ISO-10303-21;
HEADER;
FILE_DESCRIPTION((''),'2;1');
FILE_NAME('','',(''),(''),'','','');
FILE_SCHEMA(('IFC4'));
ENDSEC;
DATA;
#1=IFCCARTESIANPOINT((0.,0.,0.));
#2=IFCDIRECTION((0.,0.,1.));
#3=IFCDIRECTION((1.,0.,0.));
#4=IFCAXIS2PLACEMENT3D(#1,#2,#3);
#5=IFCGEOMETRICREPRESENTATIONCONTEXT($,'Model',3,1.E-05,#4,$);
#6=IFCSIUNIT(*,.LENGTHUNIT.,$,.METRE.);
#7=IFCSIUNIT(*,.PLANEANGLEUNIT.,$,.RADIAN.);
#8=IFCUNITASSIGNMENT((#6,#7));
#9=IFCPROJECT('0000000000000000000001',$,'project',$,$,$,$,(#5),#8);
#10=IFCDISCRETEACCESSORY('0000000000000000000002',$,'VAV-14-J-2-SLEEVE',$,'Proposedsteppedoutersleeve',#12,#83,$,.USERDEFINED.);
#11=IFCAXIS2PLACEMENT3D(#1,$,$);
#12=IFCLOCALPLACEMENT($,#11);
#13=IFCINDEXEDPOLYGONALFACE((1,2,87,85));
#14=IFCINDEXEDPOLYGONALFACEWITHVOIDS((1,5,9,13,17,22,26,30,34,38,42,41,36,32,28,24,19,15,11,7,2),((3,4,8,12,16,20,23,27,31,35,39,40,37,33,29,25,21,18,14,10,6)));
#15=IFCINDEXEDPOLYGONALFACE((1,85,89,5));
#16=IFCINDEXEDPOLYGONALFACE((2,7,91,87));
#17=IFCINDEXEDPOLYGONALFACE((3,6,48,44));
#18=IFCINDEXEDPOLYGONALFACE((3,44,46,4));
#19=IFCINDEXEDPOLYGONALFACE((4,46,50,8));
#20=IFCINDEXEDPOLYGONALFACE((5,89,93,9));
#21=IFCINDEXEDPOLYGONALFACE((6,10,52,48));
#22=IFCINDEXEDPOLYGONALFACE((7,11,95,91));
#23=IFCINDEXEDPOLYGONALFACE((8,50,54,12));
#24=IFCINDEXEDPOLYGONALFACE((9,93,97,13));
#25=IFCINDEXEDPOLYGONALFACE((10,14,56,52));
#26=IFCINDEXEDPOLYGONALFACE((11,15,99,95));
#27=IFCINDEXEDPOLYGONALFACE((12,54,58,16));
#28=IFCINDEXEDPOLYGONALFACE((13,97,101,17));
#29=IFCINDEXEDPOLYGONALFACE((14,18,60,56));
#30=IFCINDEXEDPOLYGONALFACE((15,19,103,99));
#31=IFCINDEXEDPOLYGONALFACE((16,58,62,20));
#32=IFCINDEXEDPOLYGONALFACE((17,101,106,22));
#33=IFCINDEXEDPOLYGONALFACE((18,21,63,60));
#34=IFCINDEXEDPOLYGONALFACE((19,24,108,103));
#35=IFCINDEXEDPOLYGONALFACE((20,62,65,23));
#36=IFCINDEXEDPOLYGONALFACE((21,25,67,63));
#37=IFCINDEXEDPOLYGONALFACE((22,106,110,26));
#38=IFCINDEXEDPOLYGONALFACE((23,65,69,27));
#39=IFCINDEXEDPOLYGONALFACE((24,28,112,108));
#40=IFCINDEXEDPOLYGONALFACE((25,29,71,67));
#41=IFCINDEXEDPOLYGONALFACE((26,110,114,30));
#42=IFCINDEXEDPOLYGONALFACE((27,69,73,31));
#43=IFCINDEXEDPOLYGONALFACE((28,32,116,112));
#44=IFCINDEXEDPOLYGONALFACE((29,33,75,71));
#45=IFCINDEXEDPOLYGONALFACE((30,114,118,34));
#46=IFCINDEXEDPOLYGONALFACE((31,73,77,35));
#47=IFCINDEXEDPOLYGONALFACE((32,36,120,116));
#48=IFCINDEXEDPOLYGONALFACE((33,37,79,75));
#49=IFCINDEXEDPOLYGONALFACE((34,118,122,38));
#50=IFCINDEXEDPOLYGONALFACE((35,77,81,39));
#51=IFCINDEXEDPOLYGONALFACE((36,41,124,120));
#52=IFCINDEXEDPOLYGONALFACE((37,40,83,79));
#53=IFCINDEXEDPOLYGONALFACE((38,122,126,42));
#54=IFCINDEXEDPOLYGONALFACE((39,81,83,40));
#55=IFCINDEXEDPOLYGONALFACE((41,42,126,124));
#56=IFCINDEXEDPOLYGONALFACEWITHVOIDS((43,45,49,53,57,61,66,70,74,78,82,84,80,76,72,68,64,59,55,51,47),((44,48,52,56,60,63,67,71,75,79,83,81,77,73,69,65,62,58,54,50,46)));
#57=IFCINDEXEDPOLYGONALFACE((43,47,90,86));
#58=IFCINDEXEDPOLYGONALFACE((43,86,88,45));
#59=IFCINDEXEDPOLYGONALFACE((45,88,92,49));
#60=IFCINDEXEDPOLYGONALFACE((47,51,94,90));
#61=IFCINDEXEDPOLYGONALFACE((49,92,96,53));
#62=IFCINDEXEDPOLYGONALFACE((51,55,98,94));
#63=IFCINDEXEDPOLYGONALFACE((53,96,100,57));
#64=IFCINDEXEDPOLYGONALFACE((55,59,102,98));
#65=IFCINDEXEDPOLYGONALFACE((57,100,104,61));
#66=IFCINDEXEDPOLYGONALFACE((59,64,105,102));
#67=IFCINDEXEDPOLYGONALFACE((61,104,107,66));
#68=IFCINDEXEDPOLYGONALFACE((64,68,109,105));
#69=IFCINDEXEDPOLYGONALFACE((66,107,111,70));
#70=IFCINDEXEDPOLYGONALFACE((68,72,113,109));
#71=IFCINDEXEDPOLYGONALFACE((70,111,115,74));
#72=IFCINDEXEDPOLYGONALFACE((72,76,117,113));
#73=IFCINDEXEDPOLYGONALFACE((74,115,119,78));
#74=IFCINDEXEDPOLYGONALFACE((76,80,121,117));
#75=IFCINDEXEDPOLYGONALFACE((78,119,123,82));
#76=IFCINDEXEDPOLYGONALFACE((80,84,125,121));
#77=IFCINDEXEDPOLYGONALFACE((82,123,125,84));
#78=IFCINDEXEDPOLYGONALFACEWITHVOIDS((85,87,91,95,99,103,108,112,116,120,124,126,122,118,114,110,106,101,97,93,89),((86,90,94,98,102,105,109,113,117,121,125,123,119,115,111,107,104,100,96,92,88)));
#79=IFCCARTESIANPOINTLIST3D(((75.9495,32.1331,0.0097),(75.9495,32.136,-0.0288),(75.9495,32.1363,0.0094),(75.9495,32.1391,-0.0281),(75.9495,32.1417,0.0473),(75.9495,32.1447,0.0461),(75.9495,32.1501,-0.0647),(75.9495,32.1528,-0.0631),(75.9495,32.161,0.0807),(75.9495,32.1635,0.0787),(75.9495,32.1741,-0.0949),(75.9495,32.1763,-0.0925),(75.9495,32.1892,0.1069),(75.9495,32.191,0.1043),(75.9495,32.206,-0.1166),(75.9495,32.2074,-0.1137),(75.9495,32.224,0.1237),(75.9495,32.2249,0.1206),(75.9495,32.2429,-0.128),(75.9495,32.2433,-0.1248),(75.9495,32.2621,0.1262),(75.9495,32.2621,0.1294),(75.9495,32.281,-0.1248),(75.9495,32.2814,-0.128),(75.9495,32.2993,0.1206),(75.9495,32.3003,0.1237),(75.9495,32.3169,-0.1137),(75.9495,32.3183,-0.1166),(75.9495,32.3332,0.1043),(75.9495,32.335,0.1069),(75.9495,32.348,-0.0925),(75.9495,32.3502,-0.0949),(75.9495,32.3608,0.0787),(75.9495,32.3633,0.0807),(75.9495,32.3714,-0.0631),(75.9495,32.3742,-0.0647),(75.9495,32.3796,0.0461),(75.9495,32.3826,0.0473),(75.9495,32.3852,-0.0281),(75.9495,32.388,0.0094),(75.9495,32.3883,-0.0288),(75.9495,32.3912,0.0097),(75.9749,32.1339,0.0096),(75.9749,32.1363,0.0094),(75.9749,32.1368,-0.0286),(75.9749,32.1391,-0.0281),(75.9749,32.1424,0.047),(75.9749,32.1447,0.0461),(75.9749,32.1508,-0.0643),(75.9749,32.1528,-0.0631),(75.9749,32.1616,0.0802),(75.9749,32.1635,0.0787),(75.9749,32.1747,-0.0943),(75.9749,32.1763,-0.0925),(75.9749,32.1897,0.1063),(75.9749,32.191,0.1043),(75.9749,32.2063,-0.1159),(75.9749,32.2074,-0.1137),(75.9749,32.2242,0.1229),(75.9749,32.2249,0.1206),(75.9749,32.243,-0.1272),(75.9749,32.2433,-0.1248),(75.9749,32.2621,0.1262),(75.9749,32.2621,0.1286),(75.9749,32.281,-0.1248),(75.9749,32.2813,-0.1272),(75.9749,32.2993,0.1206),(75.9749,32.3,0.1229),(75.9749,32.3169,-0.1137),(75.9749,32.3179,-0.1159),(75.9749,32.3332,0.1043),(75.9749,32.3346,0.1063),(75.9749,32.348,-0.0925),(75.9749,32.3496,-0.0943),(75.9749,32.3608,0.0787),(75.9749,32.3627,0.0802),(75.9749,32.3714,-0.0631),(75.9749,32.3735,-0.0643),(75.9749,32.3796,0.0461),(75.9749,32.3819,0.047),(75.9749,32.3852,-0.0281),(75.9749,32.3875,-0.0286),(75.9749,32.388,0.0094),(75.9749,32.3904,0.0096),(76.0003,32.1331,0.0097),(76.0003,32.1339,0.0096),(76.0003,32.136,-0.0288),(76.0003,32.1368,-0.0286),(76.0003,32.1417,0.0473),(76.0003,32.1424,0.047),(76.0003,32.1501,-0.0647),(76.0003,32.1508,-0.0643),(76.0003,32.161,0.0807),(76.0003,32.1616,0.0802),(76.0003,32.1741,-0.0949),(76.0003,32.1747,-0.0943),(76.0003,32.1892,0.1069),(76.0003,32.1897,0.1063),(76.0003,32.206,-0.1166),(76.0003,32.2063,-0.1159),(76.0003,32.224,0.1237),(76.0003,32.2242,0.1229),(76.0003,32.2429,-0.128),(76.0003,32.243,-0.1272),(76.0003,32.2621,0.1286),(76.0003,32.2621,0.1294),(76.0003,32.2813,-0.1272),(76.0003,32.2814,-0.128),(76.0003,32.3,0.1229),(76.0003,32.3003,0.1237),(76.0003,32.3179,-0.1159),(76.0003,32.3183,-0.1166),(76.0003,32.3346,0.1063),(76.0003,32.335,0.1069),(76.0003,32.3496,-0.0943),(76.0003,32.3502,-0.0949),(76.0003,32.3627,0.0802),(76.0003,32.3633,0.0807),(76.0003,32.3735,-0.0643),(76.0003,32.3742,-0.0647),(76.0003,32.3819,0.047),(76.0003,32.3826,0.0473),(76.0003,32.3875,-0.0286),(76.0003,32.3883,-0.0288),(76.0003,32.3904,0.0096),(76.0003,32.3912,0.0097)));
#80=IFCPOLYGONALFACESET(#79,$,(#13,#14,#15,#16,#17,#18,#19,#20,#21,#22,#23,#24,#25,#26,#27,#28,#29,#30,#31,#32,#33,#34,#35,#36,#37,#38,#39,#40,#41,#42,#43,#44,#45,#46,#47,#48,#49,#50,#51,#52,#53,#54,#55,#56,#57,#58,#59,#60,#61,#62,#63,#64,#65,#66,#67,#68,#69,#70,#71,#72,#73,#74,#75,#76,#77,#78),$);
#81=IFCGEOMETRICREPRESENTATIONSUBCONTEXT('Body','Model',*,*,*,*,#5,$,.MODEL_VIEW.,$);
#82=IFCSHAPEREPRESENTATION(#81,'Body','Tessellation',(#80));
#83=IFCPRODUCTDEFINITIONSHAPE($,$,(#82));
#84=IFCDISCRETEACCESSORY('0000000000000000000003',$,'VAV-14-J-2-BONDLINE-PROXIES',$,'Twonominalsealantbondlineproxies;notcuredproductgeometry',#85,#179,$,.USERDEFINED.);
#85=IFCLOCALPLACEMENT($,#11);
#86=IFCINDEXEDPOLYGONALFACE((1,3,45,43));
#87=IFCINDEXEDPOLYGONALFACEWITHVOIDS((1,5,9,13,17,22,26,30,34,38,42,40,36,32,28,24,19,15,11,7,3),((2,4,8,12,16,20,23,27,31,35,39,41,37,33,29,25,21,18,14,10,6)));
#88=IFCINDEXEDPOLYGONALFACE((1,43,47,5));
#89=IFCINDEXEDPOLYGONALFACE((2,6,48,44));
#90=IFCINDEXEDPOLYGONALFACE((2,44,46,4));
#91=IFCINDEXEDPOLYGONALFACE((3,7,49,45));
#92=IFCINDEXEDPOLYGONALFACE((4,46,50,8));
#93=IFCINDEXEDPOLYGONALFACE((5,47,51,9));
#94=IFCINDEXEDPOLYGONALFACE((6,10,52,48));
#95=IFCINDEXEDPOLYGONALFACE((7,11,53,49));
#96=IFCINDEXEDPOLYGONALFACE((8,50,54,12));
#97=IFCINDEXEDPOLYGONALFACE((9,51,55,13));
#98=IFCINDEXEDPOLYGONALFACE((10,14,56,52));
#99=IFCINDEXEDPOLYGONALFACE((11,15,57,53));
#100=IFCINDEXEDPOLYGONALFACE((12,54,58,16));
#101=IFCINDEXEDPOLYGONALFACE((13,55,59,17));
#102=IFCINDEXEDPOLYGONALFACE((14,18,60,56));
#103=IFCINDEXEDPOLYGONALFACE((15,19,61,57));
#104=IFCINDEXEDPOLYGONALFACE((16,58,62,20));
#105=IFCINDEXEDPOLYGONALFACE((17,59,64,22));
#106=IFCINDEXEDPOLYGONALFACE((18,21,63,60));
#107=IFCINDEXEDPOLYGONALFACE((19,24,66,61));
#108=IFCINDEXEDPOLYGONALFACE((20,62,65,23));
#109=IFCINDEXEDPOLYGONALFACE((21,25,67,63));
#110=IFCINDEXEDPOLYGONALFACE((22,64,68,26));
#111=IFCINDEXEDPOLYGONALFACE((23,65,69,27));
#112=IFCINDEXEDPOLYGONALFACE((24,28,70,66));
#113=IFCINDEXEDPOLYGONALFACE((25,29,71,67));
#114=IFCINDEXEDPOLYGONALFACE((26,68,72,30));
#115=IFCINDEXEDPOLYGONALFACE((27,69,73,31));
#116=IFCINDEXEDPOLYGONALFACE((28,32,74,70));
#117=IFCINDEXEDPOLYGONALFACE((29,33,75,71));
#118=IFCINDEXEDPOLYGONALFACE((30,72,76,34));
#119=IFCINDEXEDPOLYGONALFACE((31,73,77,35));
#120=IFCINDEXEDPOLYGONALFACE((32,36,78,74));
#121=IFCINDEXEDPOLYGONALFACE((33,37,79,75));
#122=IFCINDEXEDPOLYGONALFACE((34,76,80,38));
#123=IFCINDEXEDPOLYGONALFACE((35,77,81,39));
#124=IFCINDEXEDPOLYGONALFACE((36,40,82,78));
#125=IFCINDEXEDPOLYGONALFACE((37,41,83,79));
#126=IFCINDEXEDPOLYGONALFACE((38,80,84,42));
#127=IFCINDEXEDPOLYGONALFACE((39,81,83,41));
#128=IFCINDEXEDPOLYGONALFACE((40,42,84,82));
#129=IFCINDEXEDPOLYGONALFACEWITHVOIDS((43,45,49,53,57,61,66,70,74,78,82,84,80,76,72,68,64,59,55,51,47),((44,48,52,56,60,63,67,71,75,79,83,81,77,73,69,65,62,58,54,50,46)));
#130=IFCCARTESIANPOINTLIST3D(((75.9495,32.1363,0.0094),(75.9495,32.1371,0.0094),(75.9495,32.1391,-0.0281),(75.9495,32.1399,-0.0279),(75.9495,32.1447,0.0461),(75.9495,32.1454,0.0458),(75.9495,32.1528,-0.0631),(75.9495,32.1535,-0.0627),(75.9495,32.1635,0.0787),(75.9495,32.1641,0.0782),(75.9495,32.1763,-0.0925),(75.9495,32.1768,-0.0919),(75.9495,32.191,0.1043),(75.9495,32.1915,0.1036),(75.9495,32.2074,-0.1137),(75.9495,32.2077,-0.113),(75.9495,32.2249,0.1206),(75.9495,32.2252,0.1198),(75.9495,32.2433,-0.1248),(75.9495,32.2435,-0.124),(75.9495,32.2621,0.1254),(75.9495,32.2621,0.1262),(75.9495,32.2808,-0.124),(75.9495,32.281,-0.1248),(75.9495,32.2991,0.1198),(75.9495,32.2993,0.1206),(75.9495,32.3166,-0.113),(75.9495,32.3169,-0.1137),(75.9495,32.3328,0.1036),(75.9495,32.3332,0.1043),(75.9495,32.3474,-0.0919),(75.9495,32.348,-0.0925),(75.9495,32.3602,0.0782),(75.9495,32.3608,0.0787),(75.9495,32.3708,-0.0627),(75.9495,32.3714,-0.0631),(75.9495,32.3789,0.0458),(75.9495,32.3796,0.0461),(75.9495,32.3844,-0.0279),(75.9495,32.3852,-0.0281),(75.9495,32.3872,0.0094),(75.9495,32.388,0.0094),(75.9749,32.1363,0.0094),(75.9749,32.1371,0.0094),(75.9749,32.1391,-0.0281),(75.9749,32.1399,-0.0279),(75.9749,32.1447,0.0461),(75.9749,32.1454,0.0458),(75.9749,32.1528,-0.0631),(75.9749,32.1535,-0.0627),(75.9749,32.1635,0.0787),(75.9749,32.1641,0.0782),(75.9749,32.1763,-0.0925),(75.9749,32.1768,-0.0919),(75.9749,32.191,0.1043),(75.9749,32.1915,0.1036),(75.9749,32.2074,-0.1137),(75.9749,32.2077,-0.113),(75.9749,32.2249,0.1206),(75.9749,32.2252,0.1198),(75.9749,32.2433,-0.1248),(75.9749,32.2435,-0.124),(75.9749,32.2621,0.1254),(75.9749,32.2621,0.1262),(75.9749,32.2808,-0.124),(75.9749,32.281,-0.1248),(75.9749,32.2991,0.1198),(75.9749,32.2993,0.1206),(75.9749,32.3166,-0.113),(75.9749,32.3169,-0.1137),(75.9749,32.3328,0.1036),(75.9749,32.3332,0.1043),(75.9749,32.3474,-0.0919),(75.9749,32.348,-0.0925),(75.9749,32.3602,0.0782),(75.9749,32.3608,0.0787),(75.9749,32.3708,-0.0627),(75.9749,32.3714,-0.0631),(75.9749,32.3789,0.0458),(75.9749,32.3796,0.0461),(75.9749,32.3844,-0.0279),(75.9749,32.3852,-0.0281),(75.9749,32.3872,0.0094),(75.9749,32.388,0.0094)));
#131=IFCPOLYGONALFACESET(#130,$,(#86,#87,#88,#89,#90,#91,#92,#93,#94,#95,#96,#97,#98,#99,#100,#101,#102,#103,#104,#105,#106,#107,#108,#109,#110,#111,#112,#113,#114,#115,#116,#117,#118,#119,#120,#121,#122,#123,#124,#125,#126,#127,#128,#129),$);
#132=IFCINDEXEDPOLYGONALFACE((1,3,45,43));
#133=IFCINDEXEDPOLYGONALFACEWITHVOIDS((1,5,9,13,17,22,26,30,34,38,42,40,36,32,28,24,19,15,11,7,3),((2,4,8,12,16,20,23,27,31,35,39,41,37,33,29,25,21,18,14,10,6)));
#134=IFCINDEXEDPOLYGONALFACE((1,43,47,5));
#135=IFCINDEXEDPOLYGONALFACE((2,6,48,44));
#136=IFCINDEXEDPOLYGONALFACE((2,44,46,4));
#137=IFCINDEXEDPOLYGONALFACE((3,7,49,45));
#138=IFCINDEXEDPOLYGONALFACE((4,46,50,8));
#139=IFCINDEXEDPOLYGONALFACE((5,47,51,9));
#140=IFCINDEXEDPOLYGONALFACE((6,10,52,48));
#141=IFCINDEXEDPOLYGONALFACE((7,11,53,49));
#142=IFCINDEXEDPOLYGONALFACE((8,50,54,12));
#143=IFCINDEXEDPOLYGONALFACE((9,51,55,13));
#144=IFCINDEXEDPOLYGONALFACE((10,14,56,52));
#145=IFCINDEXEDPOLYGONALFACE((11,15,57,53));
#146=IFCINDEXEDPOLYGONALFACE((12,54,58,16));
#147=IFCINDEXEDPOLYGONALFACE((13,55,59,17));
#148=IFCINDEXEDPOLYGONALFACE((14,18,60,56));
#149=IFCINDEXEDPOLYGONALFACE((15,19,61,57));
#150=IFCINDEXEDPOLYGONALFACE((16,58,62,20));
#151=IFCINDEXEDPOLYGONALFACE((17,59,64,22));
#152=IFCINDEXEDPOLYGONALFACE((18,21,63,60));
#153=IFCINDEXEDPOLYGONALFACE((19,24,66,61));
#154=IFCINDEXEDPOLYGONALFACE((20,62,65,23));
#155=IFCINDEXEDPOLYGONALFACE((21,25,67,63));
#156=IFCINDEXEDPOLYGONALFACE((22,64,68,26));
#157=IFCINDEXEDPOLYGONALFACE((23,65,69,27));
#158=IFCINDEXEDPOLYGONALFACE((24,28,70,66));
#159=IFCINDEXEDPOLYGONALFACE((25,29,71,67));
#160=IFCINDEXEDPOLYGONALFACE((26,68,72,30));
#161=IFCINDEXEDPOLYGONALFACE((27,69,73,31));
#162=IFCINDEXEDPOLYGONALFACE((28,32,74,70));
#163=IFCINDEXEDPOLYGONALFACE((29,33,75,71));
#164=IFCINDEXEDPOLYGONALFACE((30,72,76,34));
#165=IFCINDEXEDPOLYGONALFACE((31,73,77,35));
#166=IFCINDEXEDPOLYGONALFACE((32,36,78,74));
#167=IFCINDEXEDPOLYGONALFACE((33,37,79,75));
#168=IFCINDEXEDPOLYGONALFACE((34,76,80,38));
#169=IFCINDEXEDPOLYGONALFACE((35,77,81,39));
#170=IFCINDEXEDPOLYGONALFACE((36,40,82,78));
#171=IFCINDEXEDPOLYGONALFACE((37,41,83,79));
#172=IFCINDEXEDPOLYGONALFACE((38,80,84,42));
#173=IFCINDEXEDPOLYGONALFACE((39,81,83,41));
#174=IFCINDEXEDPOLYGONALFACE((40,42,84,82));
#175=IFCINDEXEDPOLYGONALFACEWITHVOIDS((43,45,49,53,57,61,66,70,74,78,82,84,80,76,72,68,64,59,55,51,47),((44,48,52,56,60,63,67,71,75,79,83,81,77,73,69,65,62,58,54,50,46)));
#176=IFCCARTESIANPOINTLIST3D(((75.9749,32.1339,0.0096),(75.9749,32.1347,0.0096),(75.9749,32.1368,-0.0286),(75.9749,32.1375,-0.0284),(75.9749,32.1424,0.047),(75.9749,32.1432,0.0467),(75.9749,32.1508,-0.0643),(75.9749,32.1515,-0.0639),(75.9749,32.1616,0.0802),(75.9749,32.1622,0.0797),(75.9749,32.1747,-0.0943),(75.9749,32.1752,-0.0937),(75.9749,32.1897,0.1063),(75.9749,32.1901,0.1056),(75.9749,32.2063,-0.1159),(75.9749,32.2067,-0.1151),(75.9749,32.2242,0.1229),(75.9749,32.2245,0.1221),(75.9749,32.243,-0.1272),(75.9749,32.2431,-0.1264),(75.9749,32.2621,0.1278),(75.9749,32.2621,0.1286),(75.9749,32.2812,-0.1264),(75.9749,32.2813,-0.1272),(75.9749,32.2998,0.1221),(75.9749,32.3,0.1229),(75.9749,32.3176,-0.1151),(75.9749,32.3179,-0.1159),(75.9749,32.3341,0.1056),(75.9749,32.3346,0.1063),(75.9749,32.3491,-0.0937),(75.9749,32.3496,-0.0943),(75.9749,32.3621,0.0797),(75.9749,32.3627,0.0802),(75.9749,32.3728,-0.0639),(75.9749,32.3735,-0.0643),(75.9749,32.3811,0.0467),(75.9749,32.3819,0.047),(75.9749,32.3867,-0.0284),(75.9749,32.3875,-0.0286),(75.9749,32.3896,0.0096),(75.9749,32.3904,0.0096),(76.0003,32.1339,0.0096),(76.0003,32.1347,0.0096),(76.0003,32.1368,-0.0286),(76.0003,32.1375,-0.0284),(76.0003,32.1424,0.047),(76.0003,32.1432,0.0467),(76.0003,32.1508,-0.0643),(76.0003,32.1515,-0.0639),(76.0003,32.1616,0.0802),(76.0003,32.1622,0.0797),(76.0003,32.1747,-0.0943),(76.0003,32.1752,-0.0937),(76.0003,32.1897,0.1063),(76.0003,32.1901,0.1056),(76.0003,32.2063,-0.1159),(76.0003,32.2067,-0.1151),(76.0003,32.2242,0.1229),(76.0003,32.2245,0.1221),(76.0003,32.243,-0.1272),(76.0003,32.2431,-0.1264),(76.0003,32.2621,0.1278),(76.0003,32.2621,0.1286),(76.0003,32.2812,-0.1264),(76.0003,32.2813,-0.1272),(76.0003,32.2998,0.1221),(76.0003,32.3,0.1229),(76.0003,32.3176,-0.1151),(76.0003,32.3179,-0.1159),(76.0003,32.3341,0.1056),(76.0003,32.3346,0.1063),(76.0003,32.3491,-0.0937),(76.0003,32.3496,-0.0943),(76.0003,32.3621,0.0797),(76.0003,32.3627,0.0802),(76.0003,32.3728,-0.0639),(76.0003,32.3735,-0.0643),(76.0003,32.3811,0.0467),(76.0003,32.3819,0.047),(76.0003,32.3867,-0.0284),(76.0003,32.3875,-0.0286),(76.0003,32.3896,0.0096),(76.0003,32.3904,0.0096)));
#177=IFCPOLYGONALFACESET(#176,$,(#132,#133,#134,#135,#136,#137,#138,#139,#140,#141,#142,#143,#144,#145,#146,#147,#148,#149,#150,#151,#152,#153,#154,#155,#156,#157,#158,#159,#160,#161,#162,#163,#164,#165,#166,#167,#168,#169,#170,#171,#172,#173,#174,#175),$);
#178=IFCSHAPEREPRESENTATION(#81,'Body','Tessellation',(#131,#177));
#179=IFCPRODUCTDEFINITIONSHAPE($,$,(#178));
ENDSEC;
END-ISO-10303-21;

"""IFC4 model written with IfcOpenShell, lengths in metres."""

from ifc_helpers import new_model, entity, si_unit, frame, origin_with_axes, place, context, subcontext, project, element, save


model = new_model("IFC4")

# Units and contexts
model_context = context("Model", 3, precision=1e-05, world=origin_with_axes())
body_context = subcontext(model_context, "Body", "Model", "MODEL_VIEW")
ifc_project = project(units=[si_unit("LENGTHUNIT", "METRE"), si_unit("PLANEANGLEUNIT", "RADIAN")], contexts=[model_context])

# Discrete accessories
discrete_accessory_1_placement = place(None, frame((75.9749, 32.2621, 0.0), z_axis=(0.0, 1.0, 0.0), x_axis=(0.0, 0.0, 1.0)))
element("IfcDiscreteAccessory", 1, at=discrete_accessory_1_placement, Name="VAV-14-J-2-SLEEVE", ObjectType="Proposedsteppedoutersleeve", PredefinedType="USERDEFINED", context=body_context, shape_type="SweptSolid", body=[
    entity("IfcRevolvedAreaSolid", entity("IfcArbitraryClosedProfileDef", "AREA", None, entity("IfcPolyline", [entity("IfcCartesianPoint", [0.1262, -0.0254]), entity("IfcCartesianPoint", [0.1294, -0.0254]), entity("IfcCartesianPoint", [0.1294, 0.0254]), entity("IfcCartesianPoint", [0.1286, 0.0254]), entity("IfcCartesianPoint", [0.1286, 0.0]), entity("IfcCartesianPoint", [0.1262, 0.0]), entity("IfcCartesianPoint", [0.1262, -0.0254])])), entity("IfcAxis2Placement3D", entity("IfcCartesianPoint", [0.0, 0.0, 0.0])), entity("IfcAxis1Placement", entity("IfcCartesianPoint", [0.0, 0.0, 0.0]), entity("IfcDirection", [0.0, 1.0, 0.0])), 6.283185),
])
discrete_accessory_2_placement = place(None, frame((75.9749, 32.2621, 0.0), z_axis=(0.0, 1.0, 0.0), x_axis=(0.0, 0.0, 1.0)))
element("IfcDiscreteAccessory", 2, at=discrete_accessory_2_placement, Name="VAV-14-J-2-BONDLINE-PROXIES", ObjectType="Twonominalsealantbondlineproxies;notcuredproductgeometry", PredefinedType="USERDEFINED", context=body_context, shape_type="SweptSolid", body=[
    entity("IfcRevolvedAreaSolid", entity("IfcArbitraryClosedProfileDef", "AREA", None, entity("IfcPolyline", [entity("IfcCartesianPoint", [0.1254, -0.0254]), entity("IfcCartesianPoint", [0.1262, -0.0254]), entity("IfcCartesianPoint", [0.1262, 0.0]), entity("IfcCartesianPoint", [0.1254, 0.0]), entity("IfcCartesianPoint", [0.1254, -0.0254])])), entity("IfcAxis2Placement3D", entity("IfcCartesianPoint", [0.0, 0.0, 0.0])), entity("IfcAxis1Placement", entity("IfcCartesianPoint", [0.0, 0.0, 0.0]), entity("IfcDirection", [0.0, 1.0, 0.0])), 6.283185),
    entity("IfcRevolvedAreaSolid", entity("IfcArbitraryClosedProfileDef", "AREA", None, entity("IfcPolyline", [entity("IfcCartesianPoint", [0.1278, 0.0]), entity("IfcCartesianPoint", [0.1286, 0.0]), entity("IfcCartesianPoint", [0.1286, 0.0254]), entity("IfcCartesianPoint", [0.1278, 0.0254]), entity("IfcCartesianPoint", [0.1278, 0.0])])), entity("IfcAxis2Placement3D", entity("IfcCartesianPoint", [0.0, 0.0, 0.0])), entity("IfcAxis1Placement", entity("IfcCartesianPoint", [0.0, 0.0, 0.0]), entity("IfcDirection", [0.0, 1.0, 0.0])), 6.283185),
])

save(model, "model.ifc")
